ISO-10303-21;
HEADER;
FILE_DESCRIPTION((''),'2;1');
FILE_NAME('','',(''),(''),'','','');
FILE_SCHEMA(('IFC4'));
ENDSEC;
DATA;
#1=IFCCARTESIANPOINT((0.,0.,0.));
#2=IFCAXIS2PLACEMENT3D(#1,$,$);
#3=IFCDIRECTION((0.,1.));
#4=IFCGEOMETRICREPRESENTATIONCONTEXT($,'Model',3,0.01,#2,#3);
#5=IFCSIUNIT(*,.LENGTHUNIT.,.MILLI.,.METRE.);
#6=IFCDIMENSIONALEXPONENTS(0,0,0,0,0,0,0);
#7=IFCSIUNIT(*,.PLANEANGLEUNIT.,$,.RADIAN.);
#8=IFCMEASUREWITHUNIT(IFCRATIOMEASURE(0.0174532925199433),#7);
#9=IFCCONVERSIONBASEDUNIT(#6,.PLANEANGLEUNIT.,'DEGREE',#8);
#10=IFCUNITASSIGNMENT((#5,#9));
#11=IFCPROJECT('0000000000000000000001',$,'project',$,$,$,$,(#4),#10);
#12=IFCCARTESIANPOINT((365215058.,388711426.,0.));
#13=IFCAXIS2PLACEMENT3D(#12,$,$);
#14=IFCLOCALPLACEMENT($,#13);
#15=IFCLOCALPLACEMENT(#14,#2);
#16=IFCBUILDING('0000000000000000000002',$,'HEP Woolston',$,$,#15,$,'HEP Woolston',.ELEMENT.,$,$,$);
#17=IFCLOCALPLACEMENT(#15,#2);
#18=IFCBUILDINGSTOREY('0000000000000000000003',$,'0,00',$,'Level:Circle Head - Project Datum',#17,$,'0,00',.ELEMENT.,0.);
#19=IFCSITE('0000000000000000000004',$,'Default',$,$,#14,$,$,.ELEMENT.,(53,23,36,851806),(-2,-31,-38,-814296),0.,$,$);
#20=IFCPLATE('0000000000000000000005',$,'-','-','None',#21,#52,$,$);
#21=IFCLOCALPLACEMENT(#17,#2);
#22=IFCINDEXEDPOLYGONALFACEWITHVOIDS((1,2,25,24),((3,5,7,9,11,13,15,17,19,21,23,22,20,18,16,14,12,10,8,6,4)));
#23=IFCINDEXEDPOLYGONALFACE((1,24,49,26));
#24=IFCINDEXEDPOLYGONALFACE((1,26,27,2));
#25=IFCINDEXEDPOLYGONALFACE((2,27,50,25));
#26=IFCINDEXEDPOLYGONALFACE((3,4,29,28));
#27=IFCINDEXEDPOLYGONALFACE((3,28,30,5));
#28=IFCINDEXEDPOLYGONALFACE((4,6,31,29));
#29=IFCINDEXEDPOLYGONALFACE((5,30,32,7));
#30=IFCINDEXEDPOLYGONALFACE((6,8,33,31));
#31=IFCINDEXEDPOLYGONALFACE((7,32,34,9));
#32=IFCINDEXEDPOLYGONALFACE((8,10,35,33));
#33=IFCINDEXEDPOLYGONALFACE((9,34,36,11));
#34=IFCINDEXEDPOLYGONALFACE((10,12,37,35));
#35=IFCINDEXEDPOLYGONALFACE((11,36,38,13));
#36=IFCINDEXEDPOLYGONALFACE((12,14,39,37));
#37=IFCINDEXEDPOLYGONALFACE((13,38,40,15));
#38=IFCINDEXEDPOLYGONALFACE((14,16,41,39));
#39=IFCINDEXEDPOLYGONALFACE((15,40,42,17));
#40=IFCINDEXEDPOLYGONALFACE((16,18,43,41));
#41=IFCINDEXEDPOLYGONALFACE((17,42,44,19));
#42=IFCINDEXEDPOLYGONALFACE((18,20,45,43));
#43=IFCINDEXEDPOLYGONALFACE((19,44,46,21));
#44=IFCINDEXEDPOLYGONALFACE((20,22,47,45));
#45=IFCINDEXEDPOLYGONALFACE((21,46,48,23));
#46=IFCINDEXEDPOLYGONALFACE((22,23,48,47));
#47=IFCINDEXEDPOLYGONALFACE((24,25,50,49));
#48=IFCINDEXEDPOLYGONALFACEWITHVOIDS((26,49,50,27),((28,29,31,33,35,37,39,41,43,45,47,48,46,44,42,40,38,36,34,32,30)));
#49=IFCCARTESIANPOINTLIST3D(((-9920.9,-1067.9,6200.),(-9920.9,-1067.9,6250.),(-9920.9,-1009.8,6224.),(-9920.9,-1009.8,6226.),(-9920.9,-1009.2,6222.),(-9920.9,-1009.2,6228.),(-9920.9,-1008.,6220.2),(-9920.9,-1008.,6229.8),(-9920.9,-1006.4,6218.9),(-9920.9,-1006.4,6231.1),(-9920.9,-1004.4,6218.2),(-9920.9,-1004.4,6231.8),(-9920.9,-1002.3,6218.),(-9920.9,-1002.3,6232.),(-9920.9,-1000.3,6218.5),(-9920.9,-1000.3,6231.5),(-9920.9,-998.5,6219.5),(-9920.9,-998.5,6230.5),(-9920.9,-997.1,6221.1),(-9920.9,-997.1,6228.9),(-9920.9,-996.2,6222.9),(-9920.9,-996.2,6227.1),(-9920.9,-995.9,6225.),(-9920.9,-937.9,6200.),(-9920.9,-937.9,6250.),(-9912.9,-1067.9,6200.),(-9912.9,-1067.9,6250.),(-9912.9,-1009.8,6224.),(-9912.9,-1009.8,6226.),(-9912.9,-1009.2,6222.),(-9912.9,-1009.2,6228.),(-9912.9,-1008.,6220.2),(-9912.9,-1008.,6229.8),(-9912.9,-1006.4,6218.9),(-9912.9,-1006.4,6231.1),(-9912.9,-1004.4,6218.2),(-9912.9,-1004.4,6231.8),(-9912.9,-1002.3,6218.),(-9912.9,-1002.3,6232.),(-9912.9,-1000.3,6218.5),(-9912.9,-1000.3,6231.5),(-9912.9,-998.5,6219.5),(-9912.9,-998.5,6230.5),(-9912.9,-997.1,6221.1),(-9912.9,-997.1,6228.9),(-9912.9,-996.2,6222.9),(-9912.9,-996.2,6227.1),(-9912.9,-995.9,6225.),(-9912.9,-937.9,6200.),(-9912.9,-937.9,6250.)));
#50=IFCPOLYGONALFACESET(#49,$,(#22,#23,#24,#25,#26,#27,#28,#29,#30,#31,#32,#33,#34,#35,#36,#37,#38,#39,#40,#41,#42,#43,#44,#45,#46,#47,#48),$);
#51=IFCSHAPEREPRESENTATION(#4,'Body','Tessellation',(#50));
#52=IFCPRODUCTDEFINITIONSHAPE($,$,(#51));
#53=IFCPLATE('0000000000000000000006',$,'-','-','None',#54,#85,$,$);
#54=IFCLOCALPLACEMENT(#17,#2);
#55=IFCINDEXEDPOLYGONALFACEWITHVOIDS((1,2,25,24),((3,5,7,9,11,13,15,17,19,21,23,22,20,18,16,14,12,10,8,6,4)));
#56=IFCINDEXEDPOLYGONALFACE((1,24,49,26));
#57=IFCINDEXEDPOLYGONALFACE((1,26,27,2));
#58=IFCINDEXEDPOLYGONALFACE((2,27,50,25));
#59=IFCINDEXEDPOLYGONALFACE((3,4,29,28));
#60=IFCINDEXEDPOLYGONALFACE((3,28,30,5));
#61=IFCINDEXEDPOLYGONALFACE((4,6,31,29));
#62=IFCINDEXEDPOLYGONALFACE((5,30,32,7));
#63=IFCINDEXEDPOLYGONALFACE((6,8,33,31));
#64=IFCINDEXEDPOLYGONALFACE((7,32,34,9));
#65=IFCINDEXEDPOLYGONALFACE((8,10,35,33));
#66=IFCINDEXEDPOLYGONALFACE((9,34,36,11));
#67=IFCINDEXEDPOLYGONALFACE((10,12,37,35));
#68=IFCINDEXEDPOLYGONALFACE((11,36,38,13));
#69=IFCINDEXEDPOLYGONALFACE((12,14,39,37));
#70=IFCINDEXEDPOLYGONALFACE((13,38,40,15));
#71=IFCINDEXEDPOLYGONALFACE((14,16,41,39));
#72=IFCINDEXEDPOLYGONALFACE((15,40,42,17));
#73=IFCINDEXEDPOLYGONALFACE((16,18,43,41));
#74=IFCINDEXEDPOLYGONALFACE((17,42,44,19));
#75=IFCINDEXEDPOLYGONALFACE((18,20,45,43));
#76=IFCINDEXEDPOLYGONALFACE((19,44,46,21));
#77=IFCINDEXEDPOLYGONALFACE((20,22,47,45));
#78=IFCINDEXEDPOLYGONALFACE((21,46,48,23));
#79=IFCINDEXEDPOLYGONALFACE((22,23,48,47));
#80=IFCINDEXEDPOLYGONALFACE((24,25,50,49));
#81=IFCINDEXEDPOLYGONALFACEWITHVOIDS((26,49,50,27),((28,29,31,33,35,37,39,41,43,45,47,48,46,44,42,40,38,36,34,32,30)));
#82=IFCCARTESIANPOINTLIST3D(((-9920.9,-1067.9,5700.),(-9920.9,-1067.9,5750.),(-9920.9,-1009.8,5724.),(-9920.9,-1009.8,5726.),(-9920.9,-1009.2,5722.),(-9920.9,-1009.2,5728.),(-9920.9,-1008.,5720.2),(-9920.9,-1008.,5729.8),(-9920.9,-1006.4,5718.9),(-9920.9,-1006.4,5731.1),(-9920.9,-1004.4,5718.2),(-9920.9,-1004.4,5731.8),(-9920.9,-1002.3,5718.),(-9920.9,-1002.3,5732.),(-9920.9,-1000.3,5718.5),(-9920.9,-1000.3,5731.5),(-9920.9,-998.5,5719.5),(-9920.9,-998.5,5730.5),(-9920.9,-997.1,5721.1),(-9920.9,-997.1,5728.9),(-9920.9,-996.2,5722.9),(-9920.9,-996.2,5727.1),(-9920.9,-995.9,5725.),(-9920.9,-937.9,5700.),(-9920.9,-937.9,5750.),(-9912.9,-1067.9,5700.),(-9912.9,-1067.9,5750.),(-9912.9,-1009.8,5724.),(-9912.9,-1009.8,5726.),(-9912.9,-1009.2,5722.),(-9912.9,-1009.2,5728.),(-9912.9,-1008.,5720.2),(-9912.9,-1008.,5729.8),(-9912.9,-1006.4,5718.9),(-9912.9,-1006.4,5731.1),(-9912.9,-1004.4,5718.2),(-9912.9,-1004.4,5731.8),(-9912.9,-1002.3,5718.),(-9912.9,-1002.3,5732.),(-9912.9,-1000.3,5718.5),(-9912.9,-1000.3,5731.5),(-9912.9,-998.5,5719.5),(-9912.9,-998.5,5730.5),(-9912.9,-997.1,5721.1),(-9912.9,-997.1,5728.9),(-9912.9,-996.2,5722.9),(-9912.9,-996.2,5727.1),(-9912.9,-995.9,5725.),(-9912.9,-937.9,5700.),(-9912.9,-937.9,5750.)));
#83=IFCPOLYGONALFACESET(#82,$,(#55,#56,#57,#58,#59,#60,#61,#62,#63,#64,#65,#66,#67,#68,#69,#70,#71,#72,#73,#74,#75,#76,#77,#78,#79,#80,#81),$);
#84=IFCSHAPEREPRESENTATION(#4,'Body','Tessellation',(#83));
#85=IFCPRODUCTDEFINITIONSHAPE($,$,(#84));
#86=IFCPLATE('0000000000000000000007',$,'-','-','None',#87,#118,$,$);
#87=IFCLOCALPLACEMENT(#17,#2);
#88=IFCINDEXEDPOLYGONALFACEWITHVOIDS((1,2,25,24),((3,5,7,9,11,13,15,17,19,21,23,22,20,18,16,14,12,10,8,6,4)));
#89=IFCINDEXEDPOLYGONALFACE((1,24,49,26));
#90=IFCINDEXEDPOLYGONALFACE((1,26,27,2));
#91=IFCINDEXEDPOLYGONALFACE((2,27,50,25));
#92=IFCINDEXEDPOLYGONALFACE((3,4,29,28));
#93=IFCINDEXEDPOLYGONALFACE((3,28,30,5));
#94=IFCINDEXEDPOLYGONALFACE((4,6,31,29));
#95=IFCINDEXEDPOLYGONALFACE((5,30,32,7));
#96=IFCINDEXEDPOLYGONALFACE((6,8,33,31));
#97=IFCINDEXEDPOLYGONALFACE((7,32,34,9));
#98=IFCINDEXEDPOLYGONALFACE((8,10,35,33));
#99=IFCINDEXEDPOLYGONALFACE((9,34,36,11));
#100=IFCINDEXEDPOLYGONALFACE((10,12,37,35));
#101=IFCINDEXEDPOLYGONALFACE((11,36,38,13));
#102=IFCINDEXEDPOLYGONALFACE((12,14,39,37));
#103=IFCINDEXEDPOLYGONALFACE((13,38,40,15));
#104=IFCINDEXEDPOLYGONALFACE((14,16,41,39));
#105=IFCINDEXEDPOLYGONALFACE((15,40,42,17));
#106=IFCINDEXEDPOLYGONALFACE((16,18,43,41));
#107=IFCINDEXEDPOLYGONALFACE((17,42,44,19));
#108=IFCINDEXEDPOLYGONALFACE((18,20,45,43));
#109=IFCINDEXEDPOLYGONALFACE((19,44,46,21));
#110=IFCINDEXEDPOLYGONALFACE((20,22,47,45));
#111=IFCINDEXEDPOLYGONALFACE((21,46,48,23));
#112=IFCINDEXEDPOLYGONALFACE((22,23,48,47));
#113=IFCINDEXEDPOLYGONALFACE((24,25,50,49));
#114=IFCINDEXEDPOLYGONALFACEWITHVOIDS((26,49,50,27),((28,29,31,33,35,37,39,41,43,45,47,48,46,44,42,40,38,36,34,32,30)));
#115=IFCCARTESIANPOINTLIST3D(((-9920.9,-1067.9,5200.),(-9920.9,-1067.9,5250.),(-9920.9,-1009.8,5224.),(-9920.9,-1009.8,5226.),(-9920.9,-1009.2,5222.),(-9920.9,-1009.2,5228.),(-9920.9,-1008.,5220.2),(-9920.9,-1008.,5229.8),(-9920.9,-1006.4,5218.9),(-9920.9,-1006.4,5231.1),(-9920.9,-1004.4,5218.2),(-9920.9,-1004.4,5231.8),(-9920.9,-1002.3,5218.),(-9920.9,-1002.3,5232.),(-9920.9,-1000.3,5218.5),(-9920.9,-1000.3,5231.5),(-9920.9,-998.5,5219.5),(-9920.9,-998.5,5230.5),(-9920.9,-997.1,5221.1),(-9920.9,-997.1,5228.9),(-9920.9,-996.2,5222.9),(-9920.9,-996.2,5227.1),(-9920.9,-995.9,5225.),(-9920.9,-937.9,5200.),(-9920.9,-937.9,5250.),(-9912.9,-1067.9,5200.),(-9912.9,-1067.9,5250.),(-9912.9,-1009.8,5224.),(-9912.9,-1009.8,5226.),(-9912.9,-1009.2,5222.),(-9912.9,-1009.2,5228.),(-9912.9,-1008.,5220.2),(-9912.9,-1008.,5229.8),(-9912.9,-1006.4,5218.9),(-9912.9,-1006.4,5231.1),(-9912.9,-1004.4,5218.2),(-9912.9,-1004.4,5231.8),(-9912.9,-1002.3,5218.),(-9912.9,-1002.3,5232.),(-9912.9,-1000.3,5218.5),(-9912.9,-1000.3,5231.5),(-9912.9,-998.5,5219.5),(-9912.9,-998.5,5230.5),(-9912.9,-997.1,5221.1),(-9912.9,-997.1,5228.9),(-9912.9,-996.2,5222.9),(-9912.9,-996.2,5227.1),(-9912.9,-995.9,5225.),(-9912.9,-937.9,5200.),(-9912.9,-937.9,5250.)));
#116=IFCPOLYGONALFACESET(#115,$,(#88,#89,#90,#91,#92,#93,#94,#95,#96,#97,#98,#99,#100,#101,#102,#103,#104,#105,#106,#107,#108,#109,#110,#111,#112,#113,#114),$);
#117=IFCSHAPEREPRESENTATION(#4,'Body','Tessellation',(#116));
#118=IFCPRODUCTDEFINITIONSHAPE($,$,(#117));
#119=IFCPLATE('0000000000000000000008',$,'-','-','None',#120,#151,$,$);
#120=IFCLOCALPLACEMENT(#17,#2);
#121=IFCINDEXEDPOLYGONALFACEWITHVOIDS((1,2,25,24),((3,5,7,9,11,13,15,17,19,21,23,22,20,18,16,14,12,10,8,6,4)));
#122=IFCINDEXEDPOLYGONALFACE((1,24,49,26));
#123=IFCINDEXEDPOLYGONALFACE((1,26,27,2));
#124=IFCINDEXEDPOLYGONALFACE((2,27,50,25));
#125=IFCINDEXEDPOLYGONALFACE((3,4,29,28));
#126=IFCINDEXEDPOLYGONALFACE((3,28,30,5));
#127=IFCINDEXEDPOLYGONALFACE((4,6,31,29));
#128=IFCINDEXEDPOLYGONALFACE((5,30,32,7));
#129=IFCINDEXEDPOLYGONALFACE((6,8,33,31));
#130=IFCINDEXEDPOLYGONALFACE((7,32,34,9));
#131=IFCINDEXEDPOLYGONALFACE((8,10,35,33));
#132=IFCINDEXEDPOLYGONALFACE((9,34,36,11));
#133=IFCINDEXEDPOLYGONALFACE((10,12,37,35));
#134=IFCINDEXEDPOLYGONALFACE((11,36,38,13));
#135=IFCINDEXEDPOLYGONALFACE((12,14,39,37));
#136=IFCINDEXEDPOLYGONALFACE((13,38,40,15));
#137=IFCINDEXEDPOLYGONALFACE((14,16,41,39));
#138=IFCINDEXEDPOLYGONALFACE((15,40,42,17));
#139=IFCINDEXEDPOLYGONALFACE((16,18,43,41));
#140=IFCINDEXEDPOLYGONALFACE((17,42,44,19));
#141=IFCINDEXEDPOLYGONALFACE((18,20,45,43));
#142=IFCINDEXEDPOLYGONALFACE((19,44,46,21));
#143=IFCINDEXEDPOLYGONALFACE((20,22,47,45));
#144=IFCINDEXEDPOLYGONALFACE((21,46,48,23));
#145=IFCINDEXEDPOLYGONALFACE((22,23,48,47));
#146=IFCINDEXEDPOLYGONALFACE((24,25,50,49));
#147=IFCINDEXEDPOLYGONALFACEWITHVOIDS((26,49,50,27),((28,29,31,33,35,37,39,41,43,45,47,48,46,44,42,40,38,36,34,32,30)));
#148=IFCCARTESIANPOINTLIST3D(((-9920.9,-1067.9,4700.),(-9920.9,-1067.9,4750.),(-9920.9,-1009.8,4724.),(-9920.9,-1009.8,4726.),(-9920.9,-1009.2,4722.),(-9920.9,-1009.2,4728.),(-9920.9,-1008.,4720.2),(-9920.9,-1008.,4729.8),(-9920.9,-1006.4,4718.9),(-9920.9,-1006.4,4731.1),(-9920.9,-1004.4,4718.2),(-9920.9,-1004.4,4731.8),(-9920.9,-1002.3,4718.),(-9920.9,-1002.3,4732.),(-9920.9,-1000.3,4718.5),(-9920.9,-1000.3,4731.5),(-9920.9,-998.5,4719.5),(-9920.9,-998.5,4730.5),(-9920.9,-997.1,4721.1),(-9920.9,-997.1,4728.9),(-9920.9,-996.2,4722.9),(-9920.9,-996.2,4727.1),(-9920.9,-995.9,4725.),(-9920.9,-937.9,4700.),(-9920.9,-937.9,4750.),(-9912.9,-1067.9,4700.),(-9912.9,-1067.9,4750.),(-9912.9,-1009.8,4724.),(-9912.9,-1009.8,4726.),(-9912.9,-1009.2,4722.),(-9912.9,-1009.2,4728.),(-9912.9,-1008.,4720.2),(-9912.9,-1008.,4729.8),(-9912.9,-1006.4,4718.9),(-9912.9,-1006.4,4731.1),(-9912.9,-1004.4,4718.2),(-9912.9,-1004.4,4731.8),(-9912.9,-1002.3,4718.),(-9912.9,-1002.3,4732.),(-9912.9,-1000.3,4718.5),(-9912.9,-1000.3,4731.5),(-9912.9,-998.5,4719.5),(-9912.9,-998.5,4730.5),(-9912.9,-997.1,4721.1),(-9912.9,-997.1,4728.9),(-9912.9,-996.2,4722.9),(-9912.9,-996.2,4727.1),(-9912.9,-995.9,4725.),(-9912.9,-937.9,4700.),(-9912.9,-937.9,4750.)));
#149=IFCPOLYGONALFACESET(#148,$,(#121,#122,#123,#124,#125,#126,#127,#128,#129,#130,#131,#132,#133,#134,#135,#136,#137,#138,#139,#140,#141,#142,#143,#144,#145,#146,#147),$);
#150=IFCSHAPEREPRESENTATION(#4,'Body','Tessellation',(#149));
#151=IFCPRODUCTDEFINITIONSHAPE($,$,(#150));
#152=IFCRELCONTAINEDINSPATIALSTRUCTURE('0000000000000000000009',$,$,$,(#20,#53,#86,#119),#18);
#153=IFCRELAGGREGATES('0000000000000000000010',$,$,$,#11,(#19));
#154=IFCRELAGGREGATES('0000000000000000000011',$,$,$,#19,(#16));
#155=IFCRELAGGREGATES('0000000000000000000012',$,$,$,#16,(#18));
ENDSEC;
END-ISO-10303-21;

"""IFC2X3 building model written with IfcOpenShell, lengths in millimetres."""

from ifc_helpers import new_model, entity, si_unit, converted_unit, direction, frame, origin, origin_with_axes, origin_2d_with_axis, place, context, project, spatial, polyline, circle, outline, extrude, element, save


model = new_model("IFC2X3")

# Units and contexts
model_context = context("Model", 3, precision=0.01, world=origin(), true_north=direction((0.0, 1.0)))
ifc_project = project(units=[si_unit("LENGTHUNIT", "METRE", prefix="MILLI"), converted_unit("PLANEANGLEUNIT", "DEGREE", entity("IfcRatioMeasure", 0.0174532925199433), si_unit("PLANEANGLEUNIT", "RADIAN"), dimensions=[0, 0, 0, 0, 0, 0, 0])], contexts=[model_context])

# Site, building, storey
site_placement = place(None, frame((365215058.0, 388711426.0, 0.0)))
site = spatial("IfcSite", under=ifc_project, at=site_placement, Name="Default", CompositionType="ELEMENT", RefLatitude=(53, 23, 36, 851806), RefLongitude=(-2, -31, -38, -814296), RefElevation=0.0)
building_placement = place(site_placement, origin())
building = spatial("IfcBuilding", under=site, at=building_placement, Name="HEP Woolston", LongName="HEP Woolston", CompositionType="ELEMENT")
storey_placement = place(building_placement, origin())
storey = spatial("IfcBuildingStorey", under=building, at=storey_placement, Name="0,00", ObjectType="Level:Circle Head - Project Datum", LongName="0,00", CompositionType="ELEMENT", Elevation=0.0)

# Plates, openings
plate_1_placement = place(storey_placement, frame((-9920.9, -1067.9, 6250.0), z_axis=(1.0, 0.0, 0.0), x_axis=(0.0, 1.0, 0.0)))
plate_1 = element("IfcPlate", 1, at=plate_1_placement, inside=storey, Name="-", Description="-", ObjectType="None", context=model_context, shape_type="SweptSolid", body=[
    extrude(outline(polyline([(0.0, -50.0), (130.0, -50.0), (130.0, 0.0), (0.0, 0.0), (0.0, -50.0)])), origin_with_axes(), (0.0, 0.0, 1.0), 8.0),
])
opening_1_placement = place(plate_1_placement, frame((65.0, -25.0, 8.5), z_axis=(0.0, 0.0, -1.0), x_axis=(1.0, 0.0, 0.0)))
element("IfcOpeningElement", 2, at=opening_1_placement, cuts=plate_1, ObjectType="Opening", context=model_context, shape_type="SweptSolid", body=[
    extrude(circle(Radius=7.0, at=origin_2d_with_axis()), origin(), (0.0, 0.0, 1.0), 9.0),
])
plate_2_placement = place(storey_placement, frame((-9920.9, -1067.9, 5750.0), z_axis=(1.0, 0.0, 0.0), x_axis=(0.0, 1.0, 0.0)))
plate_2 = element("IfcPlate", 3, at=plate_2_placement, inside=storey, Name="-", Description="-", ObjectType="None", context=model_context, shape_type="SweptSolid", body=[
    extrude(outline(polyline([(0.0, -50.0), (130.0, -50.0), (130.0, 0.0), (0.0, 0.0), (0.0, -50.0)])), origin_with_axes(), (0.0, 0.0, 1.0), 8.0),
])
opening_2_placement = place(plate_2_placement, frame((65.0, -25.0, 8.5), z_axis=(0.0, 0.0, -1.0), x_axis=(1.0, 0.0, 0.0)))
element("IfcOpeningElement", 4, at=opening_2_placement, cuts=plate_2, ObjectType="Opening", context=model_context, shape_type="SweptSolid", body=[
    extrude(circle(Radius=7.0, at=origin_2d_with_axis()), origin(), (0.0, 0.0, 1.0), 9.0),
])
plate_3_placement = place(storey_placement, frame((-9920.9, -1067.9, 5250.0), z_axis=(1.0, 0.0, 0.0), x_axis=(0.0, 1.0, 0.0)))
plate_3 = element("IfcPlate", 5, at=plate_3_placement, inside=storey, Name="-", Description="-", ObjectType="None", context=model_context, shape_type="SweptSolid", body=[
    extrude(outline(polyline([(0.0, -50.0), (130.0, -50.0), (130.0, 0.0), (0.0, 0.0), (0.0, -50.0)])), origin_with_axes(), (0.0, 0.0, 1.0), 8.0),
])
opening_3_placement = place(plate_3_placement, frame((65.0, -25.0, 8.5), z_axis=(0.0, 0.0, -1.0), x_axis=(1.0, 0.0, 0.0)))
element("IfcOpeningElement", 6, at=opening_3_placement, cuts=plate_3, ObjectType="Opening", context=model_context, shape_type="SweptSolid", body=[
    extrude(circle(Radius=7.0, at=origin_2d_with_axis()), origin(), (0.0, 0.0, 1.0), 9.0),
])
plate_4_placement = place(storey_placement, frame((-9920.9, -1067.9, 4750.0), z_axis=(1.0, 0.0, 0.0), x_axis=(0.0, 1.0, 0.0)))
plate_4 = element("IfcPlate", 7, at=plate_4_placement, inside=storey, Name="-", Description="-", ObjectType="None", context=model_context, shape_type="SweptSolid", body=[
    extrude(outline(polyline([(0.0, -50.0), (130.0, -50.0), (130.0, 0.0), (0.0, 0.0), (0.0, -50.0)])), origin_with_axes(), (0.0, 0.0, 1.0), 8.0),
])
opening_4_placement = place(plate_4_placement, frame((65.0, -25.0, 8.5), z_axis=(0.0, 0.0, -1.0), x_axis=(1.0, 0.0, 0.0)))
element("IfcOpeningElement", 8, at=opening_4_placement, cuts=plate_4, ObjectType="Opening", context=model_context, shape_type="SweptSolid", body=[
    extrude(circle(Radius=7.0, at=origin_2d_with_axis()), origin(), (0.0, 0.0, 1.0), 9.0),
])

save(model, "model.ifc")
